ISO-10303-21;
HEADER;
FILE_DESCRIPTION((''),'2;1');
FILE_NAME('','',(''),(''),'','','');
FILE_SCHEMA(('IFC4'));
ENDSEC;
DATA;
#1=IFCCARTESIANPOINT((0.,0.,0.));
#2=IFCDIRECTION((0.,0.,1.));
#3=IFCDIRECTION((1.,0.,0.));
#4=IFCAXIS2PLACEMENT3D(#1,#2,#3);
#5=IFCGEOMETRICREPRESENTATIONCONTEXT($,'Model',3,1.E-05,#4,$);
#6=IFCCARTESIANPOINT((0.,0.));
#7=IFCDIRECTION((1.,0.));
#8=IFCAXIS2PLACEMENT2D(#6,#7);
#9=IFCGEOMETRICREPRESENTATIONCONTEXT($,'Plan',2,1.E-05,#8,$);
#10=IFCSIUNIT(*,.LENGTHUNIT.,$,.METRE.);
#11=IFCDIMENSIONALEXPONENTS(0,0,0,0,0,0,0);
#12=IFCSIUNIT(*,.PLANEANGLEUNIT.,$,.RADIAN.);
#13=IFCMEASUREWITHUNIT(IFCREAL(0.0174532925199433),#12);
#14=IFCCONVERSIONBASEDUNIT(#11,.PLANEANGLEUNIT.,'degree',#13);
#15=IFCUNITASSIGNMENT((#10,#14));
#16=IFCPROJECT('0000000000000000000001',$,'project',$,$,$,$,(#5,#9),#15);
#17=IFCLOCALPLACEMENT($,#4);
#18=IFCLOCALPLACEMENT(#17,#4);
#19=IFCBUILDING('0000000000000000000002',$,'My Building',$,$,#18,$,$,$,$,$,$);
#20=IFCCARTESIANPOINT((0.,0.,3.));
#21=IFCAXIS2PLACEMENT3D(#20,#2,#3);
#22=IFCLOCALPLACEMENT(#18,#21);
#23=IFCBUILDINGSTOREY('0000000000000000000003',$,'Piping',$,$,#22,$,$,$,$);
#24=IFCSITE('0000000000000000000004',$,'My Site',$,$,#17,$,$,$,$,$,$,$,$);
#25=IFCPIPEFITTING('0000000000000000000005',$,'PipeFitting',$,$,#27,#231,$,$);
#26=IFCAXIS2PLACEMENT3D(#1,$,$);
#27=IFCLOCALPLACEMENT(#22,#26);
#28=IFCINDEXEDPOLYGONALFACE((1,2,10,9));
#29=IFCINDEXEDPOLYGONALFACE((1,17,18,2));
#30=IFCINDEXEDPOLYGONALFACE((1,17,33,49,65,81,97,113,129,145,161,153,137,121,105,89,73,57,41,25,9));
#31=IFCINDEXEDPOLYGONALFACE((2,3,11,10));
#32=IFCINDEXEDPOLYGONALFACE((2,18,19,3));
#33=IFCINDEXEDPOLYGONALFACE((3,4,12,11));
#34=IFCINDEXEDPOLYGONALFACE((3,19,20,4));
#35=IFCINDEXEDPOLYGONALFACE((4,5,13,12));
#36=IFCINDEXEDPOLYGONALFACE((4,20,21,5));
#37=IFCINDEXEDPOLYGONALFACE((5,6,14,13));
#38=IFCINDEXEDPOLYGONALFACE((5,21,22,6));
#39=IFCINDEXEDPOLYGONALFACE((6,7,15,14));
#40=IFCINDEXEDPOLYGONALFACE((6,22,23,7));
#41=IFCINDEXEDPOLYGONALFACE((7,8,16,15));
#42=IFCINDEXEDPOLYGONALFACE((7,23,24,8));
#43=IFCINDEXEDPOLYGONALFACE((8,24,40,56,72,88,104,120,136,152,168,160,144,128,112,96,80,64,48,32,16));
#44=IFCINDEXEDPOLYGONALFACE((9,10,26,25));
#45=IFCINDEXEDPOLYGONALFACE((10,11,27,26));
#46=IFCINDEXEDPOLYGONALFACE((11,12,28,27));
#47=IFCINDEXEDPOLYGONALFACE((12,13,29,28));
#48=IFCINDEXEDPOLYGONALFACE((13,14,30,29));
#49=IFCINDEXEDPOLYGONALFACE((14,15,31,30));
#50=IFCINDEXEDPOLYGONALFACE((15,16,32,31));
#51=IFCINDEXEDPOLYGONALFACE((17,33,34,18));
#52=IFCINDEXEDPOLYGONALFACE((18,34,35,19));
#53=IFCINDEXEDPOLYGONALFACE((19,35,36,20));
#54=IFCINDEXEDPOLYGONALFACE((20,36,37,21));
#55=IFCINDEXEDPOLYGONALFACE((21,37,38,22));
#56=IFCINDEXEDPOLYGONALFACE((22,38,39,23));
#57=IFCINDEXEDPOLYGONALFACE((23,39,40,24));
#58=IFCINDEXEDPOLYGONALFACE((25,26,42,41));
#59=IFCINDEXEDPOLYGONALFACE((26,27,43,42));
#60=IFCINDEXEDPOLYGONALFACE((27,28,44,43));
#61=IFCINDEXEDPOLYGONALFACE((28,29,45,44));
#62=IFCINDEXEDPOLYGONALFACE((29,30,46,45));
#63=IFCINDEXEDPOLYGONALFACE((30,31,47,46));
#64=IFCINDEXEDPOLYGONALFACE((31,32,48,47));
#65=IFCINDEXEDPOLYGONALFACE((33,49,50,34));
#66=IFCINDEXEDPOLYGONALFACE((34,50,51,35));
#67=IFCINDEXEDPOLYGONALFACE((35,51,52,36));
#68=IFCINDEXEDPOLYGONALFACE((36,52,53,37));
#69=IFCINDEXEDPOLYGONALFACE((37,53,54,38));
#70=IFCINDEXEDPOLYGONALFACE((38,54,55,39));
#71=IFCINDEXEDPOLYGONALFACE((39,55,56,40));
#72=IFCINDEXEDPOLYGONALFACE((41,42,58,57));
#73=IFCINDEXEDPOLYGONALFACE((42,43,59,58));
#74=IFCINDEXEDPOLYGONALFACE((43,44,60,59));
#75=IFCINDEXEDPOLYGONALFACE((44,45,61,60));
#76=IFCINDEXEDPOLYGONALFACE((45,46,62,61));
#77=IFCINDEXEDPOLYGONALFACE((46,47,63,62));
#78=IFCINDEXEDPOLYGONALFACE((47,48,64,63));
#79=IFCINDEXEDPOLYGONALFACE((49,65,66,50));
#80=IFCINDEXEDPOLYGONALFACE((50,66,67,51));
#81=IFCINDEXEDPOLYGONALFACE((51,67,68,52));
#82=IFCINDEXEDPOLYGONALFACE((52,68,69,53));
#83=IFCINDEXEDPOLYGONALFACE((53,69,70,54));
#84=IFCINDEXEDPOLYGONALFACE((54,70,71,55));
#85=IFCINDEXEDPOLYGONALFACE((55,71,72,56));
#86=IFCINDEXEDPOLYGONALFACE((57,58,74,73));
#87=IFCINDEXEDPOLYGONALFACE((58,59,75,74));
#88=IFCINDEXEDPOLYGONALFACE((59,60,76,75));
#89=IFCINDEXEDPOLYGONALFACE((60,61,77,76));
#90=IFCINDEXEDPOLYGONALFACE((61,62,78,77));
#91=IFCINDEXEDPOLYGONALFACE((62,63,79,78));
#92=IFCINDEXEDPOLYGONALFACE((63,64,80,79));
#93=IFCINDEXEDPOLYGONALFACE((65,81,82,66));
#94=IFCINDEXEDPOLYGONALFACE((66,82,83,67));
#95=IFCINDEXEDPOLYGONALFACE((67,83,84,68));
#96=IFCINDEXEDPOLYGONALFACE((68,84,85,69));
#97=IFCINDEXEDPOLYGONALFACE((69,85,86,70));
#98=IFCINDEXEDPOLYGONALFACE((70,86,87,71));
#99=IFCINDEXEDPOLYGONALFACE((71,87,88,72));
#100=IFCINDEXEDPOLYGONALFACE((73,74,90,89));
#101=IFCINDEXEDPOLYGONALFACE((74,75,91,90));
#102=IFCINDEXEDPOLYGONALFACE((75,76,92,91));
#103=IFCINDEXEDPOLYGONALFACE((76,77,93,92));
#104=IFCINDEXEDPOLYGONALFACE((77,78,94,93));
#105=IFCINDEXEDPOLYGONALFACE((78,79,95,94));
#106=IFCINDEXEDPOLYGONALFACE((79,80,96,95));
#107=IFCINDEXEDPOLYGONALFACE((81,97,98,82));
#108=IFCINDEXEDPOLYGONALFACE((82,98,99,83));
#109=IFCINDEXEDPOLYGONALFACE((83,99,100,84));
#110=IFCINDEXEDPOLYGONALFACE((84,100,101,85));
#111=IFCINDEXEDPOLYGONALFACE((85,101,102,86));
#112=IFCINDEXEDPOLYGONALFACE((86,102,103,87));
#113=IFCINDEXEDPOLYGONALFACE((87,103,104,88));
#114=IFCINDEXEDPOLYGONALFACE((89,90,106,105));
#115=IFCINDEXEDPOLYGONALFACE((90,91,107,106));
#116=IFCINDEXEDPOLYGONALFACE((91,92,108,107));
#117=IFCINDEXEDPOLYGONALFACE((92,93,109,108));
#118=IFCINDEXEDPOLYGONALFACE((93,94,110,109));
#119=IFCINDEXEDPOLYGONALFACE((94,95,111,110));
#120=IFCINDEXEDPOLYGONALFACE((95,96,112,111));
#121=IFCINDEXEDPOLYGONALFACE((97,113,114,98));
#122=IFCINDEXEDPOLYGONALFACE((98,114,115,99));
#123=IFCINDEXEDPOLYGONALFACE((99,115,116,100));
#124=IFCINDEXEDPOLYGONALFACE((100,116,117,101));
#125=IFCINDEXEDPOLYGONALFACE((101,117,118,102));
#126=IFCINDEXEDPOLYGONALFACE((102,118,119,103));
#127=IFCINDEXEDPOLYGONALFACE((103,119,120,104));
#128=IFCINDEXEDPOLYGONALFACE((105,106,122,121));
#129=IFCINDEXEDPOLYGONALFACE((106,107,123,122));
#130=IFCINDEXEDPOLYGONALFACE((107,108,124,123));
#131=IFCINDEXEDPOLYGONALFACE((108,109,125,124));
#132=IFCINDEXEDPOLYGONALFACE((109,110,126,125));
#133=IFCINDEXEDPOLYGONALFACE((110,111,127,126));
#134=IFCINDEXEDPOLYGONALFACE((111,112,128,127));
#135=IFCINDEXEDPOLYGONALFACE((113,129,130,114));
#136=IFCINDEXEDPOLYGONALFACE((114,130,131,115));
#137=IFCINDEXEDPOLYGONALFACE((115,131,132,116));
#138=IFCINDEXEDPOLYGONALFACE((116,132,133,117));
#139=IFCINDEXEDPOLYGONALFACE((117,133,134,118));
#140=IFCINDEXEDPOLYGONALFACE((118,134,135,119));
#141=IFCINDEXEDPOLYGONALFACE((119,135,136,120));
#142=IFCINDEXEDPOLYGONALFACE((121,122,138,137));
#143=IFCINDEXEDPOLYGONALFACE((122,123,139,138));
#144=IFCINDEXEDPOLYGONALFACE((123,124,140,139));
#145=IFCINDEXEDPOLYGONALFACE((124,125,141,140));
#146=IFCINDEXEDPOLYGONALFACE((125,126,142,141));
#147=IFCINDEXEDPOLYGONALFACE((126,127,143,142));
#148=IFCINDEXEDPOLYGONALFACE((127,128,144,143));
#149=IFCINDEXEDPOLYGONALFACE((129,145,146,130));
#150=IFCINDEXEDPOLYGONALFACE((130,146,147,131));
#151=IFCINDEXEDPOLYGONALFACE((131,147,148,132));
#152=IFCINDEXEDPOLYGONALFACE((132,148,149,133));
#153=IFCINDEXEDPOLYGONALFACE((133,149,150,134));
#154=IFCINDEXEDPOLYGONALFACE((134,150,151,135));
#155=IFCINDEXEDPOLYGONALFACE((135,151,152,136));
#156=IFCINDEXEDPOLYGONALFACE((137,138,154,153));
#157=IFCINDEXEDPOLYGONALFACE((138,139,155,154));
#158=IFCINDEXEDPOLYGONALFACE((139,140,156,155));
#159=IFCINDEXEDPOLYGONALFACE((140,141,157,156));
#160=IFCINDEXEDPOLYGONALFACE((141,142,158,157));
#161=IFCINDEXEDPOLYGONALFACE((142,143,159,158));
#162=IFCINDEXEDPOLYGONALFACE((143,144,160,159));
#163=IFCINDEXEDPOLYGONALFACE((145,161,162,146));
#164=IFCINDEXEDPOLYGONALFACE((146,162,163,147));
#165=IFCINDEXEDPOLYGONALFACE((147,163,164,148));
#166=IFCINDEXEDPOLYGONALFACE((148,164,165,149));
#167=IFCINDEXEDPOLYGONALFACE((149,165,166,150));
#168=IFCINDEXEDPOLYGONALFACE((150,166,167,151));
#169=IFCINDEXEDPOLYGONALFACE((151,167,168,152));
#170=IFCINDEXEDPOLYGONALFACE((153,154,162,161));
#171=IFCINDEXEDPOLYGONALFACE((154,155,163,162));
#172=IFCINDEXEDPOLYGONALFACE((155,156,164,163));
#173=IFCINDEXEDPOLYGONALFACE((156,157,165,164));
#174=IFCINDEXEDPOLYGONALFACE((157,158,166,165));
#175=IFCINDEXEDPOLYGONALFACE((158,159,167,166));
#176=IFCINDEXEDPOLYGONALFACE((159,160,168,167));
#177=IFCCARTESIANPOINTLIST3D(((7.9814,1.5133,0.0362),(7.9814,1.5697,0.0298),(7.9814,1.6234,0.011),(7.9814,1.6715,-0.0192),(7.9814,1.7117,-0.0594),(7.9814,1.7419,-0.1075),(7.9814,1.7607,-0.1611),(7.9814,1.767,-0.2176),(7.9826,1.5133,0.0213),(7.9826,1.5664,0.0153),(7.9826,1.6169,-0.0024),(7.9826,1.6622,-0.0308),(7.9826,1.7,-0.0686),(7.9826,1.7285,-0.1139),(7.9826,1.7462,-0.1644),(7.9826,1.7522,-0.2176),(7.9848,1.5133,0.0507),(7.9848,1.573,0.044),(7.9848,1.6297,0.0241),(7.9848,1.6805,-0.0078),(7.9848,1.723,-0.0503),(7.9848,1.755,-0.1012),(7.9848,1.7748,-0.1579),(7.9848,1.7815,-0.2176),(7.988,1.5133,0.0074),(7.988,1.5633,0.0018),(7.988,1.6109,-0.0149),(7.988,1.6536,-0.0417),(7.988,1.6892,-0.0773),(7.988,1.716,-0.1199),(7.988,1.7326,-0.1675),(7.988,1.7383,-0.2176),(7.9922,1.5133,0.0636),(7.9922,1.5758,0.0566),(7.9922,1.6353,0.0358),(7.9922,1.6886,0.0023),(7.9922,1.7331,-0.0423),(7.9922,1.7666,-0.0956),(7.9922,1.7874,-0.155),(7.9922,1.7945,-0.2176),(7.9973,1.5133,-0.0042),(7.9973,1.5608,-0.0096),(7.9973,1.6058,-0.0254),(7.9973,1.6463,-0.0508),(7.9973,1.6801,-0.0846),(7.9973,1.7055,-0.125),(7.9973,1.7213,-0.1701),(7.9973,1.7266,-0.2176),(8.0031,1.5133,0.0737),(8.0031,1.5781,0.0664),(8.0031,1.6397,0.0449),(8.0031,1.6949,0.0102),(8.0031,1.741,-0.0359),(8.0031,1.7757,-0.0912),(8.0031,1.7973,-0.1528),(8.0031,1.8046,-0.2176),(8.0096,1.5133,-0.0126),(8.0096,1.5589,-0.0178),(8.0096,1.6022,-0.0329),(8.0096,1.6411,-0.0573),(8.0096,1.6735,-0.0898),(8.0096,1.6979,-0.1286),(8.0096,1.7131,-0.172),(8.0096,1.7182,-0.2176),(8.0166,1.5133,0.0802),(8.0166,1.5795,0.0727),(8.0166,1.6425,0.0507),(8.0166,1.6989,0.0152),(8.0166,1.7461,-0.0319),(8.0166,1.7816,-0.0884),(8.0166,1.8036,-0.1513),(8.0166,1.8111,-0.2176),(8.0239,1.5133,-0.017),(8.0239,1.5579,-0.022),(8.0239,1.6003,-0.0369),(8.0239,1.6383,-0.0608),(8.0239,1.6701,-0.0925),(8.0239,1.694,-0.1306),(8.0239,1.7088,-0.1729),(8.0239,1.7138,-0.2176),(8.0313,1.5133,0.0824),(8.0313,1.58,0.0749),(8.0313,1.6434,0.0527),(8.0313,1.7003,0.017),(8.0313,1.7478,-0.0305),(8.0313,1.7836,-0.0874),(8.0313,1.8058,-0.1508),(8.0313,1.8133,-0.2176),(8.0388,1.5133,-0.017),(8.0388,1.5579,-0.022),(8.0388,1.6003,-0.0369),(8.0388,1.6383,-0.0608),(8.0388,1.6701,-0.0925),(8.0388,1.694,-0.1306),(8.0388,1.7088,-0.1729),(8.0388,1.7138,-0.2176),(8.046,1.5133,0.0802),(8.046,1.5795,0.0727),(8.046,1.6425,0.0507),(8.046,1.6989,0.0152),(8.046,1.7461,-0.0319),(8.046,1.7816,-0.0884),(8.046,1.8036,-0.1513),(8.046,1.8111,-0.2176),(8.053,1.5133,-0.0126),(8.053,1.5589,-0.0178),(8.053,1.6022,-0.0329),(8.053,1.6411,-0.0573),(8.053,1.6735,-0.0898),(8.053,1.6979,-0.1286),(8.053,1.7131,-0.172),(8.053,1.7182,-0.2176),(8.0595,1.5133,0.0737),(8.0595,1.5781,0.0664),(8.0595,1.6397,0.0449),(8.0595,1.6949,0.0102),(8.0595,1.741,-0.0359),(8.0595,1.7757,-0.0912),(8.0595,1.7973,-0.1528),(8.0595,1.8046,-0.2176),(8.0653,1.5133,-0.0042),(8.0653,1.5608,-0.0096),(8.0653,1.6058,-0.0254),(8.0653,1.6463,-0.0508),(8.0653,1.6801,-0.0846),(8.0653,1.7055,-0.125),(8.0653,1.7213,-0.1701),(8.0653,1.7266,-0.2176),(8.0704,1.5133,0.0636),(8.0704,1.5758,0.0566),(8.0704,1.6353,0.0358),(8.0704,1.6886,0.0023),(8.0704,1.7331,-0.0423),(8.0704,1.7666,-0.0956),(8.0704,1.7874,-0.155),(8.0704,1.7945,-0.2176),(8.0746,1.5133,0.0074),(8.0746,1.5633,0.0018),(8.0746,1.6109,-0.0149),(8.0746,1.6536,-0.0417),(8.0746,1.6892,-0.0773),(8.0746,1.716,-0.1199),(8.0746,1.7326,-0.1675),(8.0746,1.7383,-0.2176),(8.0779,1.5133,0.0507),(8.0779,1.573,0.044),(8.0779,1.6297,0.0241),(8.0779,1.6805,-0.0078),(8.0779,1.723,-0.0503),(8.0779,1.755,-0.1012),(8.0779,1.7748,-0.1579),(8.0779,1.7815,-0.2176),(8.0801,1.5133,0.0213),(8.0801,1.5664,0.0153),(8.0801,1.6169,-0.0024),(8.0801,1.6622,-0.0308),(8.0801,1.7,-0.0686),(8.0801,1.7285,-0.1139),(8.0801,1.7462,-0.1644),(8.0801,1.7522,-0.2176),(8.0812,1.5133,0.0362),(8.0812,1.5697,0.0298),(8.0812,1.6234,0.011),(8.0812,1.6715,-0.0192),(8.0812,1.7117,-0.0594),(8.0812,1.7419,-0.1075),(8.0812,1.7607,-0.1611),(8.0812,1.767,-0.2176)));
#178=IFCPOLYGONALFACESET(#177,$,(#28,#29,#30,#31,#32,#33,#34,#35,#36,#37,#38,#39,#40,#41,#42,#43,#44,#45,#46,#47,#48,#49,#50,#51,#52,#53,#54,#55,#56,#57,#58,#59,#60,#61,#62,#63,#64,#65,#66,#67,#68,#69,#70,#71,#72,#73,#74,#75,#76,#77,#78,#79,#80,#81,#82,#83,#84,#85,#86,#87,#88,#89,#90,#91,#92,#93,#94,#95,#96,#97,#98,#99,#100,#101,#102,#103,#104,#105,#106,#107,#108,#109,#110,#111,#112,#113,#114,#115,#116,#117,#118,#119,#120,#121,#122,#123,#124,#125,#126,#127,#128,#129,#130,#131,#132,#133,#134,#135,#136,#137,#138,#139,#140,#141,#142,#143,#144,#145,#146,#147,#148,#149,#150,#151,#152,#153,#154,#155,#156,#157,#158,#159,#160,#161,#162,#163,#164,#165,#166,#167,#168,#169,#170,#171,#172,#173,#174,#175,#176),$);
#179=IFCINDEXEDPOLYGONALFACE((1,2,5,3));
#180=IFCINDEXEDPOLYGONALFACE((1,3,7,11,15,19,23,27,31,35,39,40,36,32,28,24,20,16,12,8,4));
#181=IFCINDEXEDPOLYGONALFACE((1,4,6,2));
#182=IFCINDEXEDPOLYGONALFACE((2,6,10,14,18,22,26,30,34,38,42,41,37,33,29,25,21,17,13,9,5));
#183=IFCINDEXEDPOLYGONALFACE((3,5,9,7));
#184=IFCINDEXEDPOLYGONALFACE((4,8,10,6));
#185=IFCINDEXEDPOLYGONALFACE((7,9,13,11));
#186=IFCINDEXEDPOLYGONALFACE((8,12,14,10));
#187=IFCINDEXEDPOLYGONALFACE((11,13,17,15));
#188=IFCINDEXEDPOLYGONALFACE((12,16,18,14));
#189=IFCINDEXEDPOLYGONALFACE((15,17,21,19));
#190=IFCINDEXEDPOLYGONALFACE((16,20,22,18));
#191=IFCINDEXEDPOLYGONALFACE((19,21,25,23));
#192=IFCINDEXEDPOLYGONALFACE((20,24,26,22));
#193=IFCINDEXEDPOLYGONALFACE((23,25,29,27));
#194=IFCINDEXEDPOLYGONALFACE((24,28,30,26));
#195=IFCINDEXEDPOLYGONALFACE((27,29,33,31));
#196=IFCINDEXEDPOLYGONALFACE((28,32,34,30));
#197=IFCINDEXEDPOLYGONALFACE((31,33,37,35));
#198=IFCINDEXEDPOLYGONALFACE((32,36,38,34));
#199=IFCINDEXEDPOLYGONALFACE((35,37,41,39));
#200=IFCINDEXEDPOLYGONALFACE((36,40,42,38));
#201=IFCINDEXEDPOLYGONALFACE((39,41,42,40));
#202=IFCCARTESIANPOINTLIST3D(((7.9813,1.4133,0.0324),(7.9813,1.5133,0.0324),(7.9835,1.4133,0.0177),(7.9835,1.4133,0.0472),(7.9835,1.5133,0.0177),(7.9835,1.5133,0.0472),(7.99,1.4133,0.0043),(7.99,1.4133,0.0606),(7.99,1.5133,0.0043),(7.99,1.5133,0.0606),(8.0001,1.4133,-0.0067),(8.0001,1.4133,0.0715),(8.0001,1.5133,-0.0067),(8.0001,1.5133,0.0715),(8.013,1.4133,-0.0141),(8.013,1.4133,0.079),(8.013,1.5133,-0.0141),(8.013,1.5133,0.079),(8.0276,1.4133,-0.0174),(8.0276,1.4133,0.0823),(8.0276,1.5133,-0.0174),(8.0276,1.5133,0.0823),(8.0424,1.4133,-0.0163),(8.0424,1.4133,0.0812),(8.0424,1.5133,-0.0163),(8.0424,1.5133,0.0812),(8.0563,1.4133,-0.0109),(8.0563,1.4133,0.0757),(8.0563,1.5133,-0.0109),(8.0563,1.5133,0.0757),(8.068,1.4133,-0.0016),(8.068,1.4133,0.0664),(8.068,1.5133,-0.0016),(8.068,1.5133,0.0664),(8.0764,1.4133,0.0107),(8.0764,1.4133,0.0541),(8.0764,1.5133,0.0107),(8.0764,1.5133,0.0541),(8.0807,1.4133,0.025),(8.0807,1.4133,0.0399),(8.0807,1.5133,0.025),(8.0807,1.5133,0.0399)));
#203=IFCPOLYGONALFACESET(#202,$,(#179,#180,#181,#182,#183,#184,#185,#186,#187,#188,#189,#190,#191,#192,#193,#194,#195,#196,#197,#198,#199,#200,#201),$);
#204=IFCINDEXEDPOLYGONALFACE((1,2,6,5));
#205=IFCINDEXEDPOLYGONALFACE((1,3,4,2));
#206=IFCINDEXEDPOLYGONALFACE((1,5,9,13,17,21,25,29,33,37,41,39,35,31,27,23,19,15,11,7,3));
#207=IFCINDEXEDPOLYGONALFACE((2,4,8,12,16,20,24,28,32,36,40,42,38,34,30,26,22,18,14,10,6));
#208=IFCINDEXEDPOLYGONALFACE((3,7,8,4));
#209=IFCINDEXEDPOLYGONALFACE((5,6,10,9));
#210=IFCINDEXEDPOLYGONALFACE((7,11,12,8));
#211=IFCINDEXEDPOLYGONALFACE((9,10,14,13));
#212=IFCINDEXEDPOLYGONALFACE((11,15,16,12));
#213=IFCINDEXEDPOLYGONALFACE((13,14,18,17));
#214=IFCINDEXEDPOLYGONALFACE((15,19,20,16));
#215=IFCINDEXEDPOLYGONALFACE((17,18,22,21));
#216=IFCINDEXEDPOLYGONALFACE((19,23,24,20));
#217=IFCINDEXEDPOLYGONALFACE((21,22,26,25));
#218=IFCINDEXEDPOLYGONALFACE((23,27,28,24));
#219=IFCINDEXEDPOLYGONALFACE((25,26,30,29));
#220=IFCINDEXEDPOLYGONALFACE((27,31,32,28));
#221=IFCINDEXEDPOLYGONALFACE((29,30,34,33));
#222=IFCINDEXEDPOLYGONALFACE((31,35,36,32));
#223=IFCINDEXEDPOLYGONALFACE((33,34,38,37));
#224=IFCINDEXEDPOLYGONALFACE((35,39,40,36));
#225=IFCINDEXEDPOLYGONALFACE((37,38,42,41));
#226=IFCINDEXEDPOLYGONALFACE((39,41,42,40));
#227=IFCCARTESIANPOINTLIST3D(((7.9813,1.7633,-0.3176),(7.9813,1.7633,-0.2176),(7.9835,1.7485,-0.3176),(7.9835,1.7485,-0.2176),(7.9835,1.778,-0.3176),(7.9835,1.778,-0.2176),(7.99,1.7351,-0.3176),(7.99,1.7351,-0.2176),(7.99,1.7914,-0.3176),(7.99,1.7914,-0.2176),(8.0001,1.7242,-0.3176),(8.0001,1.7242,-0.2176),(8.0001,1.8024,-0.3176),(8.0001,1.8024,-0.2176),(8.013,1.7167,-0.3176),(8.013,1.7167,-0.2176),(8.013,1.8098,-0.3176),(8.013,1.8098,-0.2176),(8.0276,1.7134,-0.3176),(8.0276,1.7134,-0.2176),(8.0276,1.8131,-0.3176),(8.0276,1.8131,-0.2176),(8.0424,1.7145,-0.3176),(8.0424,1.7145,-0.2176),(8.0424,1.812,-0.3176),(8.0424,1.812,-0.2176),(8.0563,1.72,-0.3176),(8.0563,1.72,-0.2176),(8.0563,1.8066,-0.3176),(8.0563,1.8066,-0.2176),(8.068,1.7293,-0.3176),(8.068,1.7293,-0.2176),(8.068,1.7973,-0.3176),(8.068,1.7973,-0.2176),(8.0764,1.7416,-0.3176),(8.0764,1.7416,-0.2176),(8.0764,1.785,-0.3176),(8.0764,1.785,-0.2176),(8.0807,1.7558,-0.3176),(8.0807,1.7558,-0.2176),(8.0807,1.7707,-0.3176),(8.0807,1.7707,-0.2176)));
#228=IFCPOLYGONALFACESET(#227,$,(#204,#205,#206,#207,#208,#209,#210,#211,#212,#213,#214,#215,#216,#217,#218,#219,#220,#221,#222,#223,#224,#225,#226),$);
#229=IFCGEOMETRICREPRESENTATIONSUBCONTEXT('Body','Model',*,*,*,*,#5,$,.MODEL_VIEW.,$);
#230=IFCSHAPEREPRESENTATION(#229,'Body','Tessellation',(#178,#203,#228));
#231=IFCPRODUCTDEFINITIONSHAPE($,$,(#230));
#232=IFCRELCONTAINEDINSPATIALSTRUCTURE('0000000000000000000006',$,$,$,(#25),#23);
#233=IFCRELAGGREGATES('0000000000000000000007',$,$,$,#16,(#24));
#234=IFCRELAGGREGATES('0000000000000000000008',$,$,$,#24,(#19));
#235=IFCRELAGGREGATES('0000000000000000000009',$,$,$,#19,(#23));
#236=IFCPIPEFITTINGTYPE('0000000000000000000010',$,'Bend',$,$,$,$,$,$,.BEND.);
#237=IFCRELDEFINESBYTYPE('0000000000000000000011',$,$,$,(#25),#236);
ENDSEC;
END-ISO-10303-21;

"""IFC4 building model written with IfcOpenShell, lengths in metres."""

from ifc_helpers import new_model, entity, si_unit, converted_unit, frame, origin_with_axes, origin_2d_with_axis, place, context, subcontext, project, spatial, circle, extrude, source, transform, mapped, type_object, type_shapes, element, save


model = new_model("IFC4")

# Units and contexts
model_context = context("Model", 3, precision=1e-05, world=origin_with_axes())
plan_context = context("Plan", 2, precision=1e-05, world=origin_2d_with_axis())
body_context = subcontext(model_context, "Body", "Model", "MODEL_VIEW")
ifc_project = project(units=[si_unit("LENGTHUNIT", "METRE"), converted_unit("PLANEANGLEUNIT", "degree", entity("IfcReal", 0.0174532925199433), si_unit("PLANEANGLEUNIT", "RADIAN"), dimensions=[0, 0, 0, 0, 0, 0, 0])], contexts=[model_context, plan_context])

# Site, building, storey
site_placement = place(None, origin_with_axes())
site = spatial("IfcSite", under=ifc_project, at=site_placement, Name="My Site")
building_placement = place(site_placement, origin_with_axes())
building = spatial("IfcBuilding", under=site, at=building_placement, Name="My Building")
storey_placement = place(building_placement, frame((0.0, 0.0, 3.0), z_axis=(0.0, 0.0, 1.0), x_axis=(1.0, 0.0, 0.0)))
storey = spatial("IfcBuildingStorey", under=building, at=storey_placement, Name="Piping")

# Pipe fitting
pipe_fitting_type_1 = type_object("IfcPipeFittingType", Name="Bend", PredefinedType="BEND")
shared_shape_1 = source(origin_with_axes(), body_context, "Body", "SolidModel", [
    entity("IfcSweptDiskSolid", entity("IfcIndexedPolyCurve", entity("IfcCartesianPointList3D", [[0.0, 0.0, 0.1], [0.0, -0.0732, 0.2768], [0.0, -0.25, 0.35]]), [entity("IfcArcIndex", [1, 2, 3])]), 0.05),
    extrude(circle(Radius=0.05), origin_with_axes(), (0.0, 0.0, 1.0), 0.1),
    extrude(circle(Radius=0.05), frame((0.0, -0.25, 0.35), z_axis=(0.0, -1.0, 0.0), x_axis=(1.0, 0.0, 0.0)), (0.0, 0.0, 1.0), 0.1),
])
type_shapes(pipe_fitting_type_1, [shared_shape_1])
for number, where, z_axis, x_axis, name in (
    (1, (8.0313, 1.4133, 0.0324), (0.0, 1.0, 0.0), (-1.0, 0.0, 0.0), "PipeFitting"),
):
    element("IfcPipeFitting", number, at=place(storey_placement, frame(where, z_axis=z_axis, x_axis=x_axis)), inside=storey, type_object=pipe_fitting_type_1, Name=name, context=body_context, shape_type="MappedRepresentation", body=[
        mapped(shared_shape_1, transform((0.0, 0.0, 0.0), x_axis=(1.0, 0.0, 0.0), y_axis=(0.0, 1.0, 0.0), z_axis=(0.0, 0.0, 1.0), scale=1.0)),
    ])

save(model, "model.ifc")
